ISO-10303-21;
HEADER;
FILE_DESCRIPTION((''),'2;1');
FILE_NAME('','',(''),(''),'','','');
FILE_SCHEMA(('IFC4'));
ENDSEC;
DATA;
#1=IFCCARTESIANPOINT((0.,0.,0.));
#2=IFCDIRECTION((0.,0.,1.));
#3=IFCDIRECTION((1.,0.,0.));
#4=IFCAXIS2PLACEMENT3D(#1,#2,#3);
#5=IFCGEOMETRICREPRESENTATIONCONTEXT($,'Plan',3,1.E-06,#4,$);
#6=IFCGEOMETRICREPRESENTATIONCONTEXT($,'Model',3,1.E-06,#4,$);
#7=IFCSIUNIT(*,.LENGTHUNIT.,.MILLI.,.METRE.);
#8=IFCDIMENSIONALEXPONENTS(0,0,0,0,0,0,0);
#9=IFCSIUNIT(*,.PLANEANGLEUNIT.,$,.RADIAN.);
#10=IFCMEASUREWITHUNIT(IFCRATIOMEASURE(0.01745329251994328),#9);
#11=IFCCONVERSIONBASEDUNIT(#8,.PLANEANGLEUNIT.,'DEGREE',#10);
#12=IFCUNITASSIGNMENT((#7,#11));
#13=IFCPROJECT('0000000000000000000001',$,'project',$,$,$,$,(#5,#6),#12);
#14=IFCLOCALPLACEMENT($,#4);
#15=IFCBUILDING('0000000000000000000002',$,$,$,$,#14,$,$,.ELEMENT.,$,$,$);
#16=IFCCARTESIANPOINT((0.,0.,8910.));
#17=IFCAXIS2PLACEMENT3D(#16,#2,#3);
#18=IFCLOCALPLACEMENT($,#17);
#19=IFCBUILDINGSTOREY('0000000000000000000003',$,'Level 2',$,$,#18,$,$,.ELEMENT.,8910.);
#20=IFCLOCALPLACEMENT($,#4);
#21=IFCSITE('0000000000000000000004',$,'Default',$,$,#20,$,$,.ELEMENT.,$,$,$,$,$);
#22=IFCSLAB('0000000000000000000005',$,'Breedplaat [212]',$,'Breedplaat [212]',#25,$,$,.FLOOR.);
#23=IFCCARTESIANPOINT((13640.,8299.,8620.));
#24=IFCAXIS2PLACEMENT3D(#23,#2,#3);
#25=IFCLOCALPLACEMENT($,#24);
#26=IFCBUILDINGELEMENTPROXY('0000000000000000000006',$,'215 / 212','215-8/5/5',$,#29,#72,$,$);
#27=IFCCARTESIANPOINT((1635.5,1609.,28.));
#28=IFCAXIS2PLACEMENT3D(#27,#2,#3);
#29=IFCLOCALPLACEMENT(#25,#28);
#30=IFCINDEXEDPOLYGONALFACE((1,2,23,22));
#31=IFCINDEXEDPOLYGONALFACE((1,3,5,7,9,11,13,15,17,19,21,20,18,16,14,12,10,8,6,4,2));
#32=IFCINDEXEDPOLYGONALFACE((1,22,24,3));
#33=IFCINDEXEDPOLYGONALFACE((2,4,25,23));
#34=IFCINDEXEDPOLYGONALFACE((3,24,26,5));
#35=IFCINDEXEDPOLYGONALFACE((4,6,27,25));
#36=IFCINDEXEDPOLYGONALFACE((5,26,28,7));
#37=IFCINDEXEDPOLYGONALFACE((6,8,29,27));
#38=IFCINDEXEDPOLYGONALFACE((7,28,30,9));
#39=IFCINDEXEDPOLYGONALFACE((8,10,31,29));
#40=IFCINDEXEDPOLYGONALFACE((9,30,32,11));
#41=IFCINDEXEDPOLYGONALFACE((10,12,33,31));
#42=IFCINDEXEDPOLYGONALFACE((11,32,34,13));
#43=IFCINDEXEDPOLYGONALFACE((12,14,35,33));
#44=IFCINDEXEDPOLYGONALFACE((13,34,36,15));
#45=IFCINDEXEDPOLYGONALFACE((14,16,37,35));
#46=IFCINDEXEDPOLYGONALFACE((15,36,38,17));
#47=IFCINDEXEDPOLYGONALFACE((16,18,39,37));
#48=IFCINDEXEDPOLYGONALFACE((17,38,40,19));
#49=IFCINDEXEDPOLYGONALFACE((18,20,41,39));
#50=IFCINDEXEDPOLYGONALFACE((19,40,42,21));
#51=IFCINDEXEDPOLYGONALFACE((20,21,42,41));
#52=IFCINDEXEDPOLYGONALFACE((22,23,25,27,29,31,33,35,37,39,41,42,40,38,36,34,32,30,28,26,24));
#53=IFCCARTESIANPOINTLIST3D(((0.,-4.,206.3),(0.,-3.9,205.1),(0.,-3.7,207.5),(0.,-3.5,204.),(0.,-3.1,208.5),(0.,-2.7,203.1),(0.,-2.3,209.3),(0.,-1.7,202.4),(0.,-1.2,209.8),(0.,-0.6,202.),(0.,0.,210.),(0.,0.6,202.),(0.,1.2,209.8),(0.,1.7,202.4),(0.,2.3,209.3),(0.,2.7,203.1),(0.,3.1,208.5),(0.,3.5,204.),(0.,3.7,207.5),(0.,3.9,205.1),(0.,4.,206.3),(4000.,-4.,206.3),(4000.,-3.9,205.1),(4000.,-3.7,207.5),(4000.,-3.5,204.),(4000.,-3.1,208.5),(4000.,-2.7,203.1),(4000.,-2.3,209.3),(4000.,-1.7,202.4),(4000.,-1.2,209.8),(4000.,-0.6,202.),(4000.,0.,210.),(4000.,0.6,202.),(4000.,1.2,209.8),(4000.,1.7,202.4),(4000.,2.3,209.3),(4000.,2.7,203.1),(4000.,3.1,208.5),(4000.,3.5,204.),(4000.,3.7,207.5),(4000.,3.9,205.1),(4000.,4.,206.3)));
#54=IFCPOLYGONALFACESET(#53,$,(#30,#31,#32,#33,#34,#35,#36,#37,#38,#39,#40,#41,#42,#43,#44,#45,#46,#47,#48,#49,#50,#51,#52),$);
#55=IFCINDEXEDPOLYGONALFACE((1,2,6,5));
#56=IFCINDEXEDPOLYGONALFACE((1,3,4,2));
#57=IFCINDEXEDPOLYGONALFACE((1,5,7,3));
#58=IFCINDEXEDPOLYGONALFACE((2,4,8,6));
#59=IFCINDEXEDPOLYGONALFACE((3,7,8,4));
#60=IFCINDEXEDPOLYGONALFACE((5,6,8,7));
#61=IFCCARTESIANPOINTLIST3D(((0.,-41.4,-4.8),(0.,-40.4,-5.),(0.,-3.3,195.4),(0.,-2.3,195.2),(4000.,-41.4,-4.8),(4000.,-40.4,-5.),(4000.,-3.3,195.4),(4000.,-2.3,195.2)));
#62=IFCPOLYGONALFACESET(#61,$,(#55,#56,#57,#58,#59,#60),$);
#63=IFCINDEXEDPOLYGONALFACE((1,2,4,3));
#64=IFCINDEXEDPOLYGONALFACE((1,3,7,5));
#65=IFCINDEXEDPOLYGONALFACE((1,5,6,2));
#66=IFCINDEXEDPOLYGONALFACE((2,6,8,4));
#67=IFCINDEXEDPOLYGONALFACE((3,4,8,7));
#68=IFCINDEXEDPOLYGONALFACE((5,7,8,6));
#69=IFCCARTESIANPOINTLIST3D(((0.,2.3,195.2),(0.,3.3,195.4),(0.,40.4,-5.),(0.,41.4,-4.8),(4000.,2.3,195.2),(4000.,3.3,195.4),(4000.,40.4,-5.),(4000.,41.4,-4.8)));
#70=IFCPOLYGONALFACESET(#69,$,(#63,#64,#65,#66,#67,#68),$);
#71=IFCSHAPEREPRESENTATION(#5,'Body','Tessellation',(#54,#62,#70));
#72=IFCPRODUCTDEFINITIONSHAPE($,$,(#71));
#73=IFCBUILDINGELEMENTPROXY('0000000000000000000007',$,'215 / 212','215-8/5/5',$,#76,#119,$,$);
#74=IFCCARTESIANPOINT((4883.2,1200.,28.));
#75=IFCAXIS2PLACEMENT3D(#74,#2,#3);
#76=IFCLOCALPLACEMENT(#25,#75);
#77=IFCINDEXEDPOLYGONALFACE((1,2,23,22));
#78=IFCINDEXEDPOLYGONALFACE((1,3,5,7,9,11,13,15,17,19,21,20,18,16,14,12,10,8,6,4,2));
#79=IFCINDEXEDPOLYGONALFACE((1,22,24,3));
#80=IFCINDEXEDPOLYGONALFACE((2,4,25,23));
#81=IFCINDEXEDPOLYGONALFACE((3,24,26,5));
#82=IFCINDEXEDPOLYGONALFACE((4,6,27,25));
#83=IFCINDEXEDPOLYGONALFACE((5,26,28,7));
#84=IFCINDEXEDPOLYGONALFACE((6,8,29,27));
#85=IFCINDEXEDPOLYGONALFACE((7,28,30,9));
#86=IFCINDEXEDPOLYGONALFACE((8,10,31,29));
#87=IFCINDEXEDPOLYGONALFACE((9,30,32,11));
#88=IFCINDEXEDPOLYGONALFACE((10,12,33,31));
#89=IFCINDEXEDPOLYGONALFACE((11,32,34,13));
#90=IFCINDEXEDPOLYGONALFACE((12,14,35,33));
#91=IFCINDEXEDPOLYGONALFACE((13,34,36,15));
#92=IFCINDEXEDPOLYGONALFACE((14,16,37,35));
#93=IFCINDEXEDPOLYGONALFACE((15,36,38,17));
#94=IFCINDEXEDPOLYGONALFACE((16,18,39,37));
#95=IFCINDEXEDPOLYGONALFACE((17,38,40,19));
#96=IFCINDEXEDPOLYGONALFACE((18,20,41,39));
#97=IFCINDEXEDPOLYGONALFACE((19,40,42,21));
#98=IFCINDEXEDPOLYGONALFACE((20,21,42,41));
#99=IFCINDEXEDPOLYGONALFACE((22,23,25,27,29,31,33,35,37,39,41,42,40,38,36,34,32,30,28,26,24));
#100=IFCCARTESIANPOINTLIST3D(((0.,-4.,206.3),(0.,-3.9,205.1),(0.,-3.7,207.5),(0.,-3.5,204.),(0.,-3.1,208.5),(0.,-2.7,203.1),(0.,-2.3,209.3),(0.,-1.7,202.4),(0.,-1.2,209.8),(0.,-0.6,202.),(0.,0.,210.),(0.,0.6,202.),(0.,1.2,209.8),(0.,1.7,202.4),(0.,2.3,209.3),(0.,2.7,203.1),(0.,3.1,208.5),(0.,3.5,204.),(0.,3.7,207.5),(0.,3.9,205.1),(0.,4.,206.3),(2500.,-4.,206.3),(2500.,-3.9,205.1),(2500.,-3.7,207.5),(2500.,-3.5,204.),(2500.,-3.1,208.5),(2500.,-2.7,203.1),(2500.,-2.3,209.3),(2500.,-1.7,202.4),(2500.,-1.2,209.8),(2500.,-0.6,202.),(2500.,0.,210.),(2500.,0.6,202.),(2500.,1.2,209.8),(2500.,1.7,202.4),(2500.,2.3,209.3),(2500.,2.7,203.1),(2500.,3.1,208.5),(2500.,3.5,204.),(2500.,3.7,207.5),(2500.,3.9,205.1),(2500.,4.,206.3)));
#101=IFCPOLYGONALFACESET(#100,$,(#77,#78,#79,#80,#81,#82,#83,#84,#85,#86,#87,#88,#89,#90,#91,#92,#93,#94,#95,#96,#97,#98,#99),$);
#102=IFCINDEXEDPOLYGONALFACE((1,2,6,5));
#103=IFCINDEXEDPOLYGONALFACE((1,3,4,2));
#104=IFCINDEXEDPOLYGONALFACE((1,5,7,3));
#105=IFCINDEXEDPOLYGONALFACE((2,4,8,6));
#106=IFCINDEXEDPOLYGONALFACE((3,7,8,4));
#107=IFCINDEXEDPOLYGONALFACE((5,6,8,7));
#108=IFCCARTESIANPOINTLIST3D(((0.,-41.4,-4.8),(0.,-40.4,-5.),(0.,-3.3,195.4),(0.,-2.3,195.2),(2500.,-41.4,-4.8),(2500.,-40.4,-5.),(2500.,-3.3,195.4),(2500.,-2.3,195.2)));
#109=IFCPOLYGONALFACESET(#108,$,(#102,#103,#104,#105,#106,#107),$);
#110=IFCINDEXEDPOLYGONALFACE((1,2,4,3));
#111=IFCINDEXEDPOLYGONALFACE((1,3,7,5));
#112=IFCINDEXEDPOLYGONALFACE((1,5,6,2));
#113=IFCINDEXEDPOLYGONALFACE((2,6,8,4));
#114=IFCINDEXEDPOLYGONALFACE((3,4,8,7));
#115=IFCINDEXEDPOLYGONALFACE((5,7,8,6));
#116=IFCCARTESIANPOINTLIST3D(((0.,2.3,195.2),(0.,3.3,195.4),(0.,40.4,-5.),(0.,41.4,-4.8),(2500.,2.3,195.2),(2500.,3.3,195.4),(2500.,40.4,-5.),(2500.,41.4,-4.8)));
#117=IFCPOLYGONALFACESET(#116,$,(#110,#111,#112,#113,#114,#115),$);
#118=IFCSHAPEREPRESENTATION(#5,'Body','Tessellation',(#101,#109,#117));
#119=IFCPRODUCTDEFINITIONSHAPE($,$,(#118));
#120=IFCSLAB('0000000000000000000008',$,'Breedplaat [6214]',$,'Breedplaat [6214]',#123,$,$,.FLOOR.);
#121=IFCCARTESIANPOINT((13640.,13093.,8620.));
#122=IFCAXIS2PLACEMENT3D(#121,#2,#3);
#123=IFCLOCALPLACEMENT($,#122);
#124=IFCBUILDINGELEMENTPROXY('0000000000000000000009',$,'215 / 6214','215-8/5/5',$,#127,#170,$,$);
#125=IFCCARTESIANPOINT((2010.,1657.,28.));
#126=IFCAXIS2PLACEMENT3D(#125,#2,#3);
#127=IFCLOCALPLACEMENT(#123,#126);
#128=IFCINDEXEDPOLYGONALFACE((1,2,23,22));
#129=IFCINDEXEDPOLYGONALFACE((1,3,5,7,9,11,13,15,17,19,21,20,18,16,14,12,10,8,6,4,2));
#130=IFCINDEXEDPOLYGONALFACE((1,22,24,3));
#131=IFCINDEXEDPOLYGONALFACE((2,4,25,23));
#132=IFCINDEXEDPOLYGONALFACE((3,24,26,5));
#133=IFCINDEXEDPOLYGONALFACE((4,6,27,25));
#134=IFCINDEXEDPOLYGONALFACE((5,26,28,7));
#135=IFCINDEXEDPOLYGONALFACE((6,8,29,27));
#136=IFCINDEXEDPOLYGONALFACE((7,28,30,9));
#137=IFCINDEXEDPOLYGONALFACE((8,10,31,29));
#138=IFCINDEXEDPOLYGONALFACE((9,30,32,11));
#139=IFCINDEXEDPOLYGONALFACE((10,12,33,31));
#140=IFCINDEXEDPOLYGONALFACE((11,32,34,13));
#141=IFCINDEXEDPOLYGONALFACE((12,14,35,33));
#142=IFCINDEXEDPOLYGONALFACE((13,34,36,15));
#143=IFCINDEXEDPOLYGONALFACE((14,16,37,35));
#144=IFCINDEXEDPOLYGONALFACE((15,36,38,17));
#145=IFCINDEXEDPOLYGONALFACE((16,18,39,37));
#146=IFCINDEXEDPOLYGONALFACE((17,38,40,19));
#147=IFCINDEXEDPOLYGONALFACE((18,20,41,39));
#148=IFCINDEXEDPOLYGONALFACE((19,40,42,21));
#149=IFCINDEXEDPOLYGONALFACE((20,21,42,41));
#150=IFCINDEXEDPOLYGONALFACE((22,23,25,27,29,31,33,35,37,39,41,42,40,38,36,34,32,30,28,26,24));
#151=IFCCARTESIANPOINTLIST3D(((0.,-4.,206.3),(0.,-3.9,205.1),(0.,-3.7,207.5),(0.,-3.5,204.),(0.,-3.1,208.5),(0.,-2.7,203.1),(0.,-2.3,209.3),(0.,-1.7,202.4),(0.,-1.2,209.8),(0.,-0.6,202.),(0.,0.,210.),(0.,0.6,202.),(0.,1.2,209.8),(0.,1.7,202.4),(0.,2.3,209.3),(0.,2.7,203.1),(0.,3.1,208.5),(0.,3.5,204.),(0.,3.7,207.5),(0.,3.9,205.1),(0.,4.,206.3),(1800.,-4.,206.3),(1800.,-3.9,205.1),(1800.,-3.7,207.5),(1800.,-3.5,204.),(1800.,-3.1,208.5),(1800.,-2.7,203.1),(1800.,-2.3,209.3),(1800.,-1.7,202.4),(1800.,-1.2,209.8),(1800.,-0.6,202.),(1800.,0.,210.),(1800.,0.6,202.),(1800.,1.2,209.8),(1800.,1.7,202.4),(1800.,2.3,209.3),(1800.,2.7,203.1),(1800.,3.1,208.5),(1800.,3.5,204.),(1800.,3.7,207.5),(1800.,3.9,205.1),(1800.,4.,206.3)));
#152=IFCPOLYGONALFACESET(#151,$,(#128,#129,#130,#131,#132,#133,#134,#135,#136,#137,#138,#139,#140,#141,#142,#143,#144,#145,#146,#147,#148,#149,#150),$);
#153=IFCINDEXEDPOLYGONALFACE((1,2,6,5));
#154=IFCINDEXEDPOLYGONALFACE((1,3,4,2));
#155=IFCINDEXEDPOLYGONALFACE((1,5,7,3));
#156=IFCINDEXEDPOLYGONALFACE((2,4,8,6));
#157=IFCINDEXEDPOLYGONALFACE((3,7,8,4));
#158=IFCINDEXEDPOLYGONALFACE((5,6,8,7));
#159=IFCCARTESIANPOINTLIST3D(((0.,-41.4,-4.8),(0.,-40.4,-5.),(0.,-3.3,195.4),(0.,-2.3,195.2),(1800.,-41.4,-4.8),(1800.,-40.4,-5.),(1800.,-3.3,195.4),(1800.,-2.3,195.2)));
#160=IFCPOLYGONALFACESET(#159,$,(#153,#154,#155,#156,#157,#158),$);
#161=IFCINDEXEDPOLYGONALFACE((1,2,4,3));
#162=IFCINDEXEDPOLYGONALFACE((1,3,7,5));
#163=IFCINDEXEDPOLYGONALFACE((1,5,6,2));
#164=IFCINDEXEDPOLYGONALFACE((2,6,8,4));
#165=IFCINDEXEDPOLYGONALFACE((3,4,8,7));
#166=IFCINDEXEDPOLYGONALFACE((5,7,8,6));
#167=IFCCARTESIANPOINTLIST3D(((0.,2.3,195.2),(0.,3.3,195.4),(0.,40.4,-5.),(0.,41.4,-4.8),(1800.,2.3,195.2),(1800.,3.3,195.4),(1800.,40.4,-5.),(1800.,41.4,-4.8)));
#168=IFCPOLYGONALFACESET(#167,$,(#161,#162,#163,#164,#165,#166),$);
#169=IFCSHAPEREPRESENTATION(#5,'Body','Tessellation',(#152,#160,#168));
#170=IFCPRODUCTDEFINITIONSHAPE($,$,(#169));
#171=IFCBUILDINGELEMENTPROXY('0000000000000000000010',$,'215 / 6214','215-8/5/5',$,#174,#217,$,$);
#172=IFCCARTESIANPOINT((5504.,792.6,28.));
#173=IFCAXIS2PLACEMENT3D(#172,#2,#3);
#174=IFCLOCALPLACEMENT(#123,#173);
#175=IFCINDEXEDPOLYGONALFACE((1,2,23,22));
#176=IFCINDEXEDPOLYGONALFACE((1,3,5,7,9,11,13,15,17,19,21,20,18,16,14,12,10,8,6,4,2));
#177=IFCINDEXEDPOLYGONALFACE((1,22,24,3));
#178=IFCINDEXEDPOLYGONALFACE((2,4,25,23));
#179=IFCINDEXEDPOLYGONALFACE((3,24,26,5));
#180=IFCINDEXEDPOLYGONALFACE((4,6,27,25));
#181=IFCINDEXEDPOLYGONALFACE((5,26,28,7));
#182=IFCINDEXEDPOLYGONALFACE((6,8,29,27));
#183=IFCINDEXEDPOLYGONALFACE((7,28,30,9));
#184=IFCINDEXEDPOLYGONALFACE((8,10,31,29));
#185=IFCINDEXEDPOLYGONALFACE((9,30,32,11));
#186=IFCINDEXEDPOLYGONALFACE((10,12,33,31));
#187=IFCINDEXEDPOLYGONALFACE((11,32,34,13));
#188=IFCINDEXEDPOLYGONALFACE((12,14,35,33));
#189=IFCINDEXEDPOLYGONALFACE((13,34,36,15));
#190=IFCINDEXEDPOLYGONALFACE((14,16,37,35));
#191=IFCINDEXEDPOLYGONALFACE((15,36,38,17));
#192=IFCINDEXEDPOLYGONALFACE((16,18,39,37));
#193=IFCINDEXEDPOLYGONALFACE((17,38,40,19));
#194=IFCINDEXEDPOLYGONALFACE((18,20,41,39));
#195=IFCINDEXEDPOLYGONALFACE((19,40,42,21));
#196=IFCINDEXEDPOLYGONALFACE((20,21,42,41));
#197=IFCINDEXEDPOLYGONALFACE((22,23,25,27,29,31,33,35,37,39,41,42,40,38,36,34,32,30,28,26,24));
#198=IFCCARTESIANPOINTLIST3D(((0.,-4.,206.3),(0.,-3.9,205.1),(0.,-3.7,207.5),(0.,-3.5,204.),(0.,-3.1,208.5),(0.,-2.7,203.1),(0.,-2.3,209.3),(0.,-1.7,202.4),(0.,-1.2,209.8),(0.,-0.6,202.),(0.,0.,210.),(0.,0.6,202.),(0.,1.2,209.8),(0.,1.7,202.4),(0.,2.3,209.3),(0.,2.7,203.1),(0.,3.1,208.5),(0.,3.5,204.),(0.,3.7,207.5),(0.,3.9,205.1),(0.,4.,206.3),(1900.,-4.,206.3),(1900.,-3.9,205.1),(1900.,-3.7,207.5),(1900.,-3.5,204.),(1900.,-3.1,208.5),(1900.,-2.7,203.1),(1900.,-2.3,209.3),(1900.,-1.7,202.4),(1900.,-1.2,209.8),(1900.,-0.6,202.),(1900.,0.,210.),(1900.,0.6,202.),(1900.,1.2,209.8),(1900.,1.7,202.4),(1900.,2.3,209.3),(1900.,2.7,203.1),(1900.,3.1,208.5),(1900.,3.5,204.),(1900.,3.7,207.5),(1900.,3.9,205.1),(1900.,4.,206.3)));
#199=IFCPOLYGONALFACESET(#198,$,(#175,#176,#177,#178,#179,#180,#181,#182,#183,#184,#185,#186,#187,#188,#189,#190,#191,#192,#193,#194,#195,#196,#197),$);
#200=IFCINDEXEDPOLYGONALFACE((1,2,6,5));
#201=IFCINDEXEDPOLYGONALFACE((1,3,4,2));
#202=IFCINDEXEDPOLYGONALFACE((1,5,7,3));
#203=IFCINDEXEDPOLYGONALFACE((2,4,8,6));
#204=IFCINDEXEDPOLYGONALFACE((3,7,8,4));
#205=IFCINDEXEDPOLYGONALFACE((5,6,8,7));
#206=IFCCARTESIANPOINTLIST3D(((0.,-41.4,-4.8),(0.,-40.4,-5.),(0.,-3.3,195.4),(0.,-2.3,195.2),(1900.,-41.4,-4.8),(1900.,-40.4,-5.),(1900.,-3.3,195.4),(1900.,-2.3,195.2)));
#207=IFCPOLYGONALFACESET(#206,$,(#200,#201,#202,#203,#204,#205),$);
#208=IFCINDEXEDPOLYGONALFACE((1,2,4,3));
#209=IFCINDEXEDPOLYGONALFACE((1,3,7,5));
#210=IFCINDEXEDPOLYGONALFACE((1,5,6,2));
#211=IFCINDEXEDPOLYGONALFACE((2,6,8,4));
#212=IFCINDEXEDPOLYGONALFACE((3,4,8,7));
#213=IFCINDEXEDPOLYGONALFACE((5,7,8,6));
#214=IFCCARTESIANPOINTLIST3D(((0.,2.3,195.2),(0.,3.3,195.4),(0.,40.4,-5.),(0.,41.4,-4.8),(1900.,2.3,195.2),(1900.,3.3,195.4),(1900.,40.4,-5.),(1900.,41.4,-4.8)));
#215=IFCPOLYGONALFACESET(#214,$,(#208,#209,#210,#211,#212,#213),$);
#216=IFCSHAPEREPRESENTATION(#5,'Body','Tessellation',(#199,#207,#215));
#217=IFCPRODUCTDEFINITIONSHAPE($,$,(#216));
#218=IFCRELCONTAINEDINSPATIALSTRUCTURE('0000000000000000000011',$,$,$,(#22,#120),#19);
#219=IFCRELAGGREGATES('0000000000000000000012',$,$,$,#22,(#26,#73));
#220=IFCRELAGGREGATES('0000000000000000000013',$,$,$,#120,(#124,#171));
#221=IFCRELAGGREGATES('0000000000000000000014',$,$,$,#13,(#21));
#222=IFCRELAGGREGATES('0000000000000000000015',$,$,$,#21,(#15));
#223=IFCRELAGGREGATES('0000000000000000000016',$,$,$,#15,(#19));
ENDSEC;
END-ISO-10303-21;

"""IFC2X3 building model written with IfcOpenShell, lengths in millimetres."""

from ifc_helpers import new_model, entity, si_unit, converted_unit, frame, origin_with_axes, origin_2d_with_axis, place, context, project, spatial, rectangle, circle, extrude, element, aggregate, save


model = new_model("IFC2X3")

# Units and contexts
plan_context = context("Plan", 3, precision=1e-06, world=origin_with_axes())
model_context = context("Model", 3, precision=1e-06, world=origin_with_axes())
ifc_project = project(units=[si_unit("LENGTHUNIT", "METRE", prefix="MILLI"), converted_unit("PLANEANGLEUNIT", "DEGREE", entity("IfcRatioMeasure", 0.01745329251994328), si_unit("PLANEANGLEUNIT", "RADIAN"), dimensions=[0, 0, 0, 0, 0, 0, 0])], contexts=[plan_context, model_context])

# Site, building, storey
site_placement = place(None, origin_with_axes())
site = spatial("IfcSite", under=ifc_project, at=site_placement, Name="Default", CompositionType="ELEMENT")
building_placement = place(None, origin_with_axes())
building = spatial("IfcBuilding", under=site, at=building_placement, CompositionType="ELEMENT")
storey_placement = place(None, frame((0.0, 0.0, 8910.0), z_axis=(0.0, 0.0, 1.0), x_axis=(1.0, 0.0, 0.0)))
storey = spatial("IfcBuildingStorey", under=building, at=storey_placement, Name="Level 2", CompositionType="ELEMENT", Elevation=8910.0)

# Slabs, building element proxies
slab_1_placement = place(None, frame((13640.0, 8299.0, 8620.0), z_axis=(0.0, 0.0, 1.0), x_axis=(1.0, 0.0, 0.0)))
slab_1 = element("IfcSlab", 1, at=slab_1_placement, inside=storey, Name="Breedplaat [212]", ObjectType="Breedplaat [212]", PredefinedType="FLOOR")
proxy_1_placement = place(slab_1_placement, frame((1635.5, 1609.0, 28.0), z_axis=(0.0, 0.0, 1.0), x_axis=(1.0, 0.0, 0.0)))
proxy_1 = element("IfcBuildingElementProxy", 2, at=proxy_1_placement, Name="215 / 212", Description="215-8/5/5", context=plan_context, shape_type="SweptSolid", body=[
    extrude(circle(Radius=4.0, at=origin_2d_with_axis()), frame((0.0, 0.0, 206.0), z_axis=(1.0, 0.0, 0.0), x_axis=(0.0, 0.0, 1.0)), (0.0, 0.0, 1.0), 4000.0),
    extrude(rectangle(XDim=203.8, YDim=1.0, at=origin_2d_with_axis()), frame((0.0, -21.9, 95.2), z_axis=(1.0, 0.0, 0.0), x_axis=(0.0, 0.187112, 0.982339)), (0.0, 0.0, 1.0), 4000.0),
    extrude(rectangle(XDim=203.8, YDim=1.0, at=origin_2d_with_axis()), frame((0.0, 21.9, 95.2), z_axis=(1.0, 0.0, 0.0), x_axis=(0.0, -0.187112, 0.982339)), (0.0, 0.0, 1.0), 4000.0),
])
proxy_2_placement = place(slab_1_placement, frame((4883.2, 1200.0, 28.0), z_axis=(0.0, 0.0, 1.0), x_axis=(1.0, 0.0, 0.0)))
proxy_2 = element("IfcBuildingElementProxy", 3, at=proxy_2_placement, Name="215 / 212", Description="215-8/5/5", context=plan_context, shape_type="SweptSolid", body=[
    extrude(circle(Radius=4.0, at=origin_2d_with_axis()), frame((0.0, 0.0, 206.0), z_axis=(1.0, 0.0, 0.0), x_axis=(0.0, 0.0, 1.0)), (0.0, 0.0, 1.0), 2500.0),
    extrude(rectangle(XDim=203.8, YDim=1.0, at=origin_2d_with_axis()), frame((0.0, -21.9, 95.2), z_axis=(1.0, 0.0, 0.0), x_axis=(0.0, 0.187112, 0.982339)), (0.0, 0.0, 1.0), 2500.0),
    extrude(rectangle(XDim=203.8, YDim=1.0, at=origin_2d_with_axis()), frame((0.0, 21.9, 95.2), z_axis=(1.0, 0.0, 0.0), x_axis=(0.0, -0.187112, 0.982339)), (0.0, 0.0, 1.0), 2500.0),
])
aggregate(slab_1, [proxy_1, proxy_2])
slab_2_placement = place(None, frame((13640.0, 13093.0, 8620.0), z_axis=(0.0, 0.0, 1.0), x_axis=(1.0, 0.0, 0.0)))
slab_2 = element("IfcSlab", 4, at=slab_2_placement, inside=storey, Name="Breedplaat [6214]", ObjectType="Breedplaat [6214]", PredefinedType="FLOOR")
proxy_3_placement = place(slab_2_placement, frame((2010.0, 1657.0, 28.0), z_axis=(0.0, 0.0, 1.0), x_axis=(1.0, 0.0, 0.0)))
proxy_3 = element("IfcBuildingElementProxy", 5, at=proxy_3_placement, Name="215 / 6214", Description="215-8/5/5", context=plan_context, shape_type="SweptSolid", body=[
    extrude(circle(Radius=4.0, at=origin_2d_with_axis()), frame((0.0, 0.0, 206.0), z_axis=(1.0, 0.0, 0.0), x_axis=(0.0, 0.0, 1.0)), (0.0, 0.0, 1.0), 1800.0),
    extrude(rectangle(XDim=203.8, YDim=1.0, at=origin_2d_with_axis()), frame((0.0, -21.9, 95.2), z_axis=(1.0, 0.0, 0.0), x_axis=(0.0, 0.187112, 0.982339)), (0.0, 0.0, 1.0), 1800.0),
    extrude(rectangle(XDim=203.8, YDim=1.0, at=origin_2d_with_axis()), frame((0.0, 21.9, 95.2), z_axis=(1.0, 0.0, 0.0), x_axis=(0.0, -0.187112, 0.982339)), (0.0, 0.0, 1.0), 1800.0),
])
proxy_4_placement = place(slab_2_placement, frame((5504.0, 792.6, 28.0), z_axis=(0.0, 0.0, 1.0), x_axis=(1.0, 0.0, 0.0)))
proxy_4 = element("IfcBuildingElementProxy", 6, at=proxy_4_placement, Name="215 / 6214", Description="215-8/5/5", context=plan_context, shape_type="SweptSolid", body=[
    extrude(circle(Radius=4.0, at=origin_2d_with_axis()), frame((0.0, 0.0, 206.0), z_axis=(1.0, 0.0, 0.0), x_axis=(0.0, 0.0, 1.0)), (0.0, 0.0, 1.0), 1900.0),
    extrude(rectangle(XDim=203.8, YDim=1.0, at=origin_2d_with_axis()), frame((0.0, -21.9, 95.2), z_axis=(1.0, 0.0, 0.0), x_axis=(0.0, 0.187112, 0.982339)), (0.0, 0.0, 1.0), 1900.0),
    extrude(rectangle(XDim=203.8, YDim=1.0, at=origin_2d_with_axis()), frame((0.0, 21.9, 95.2), z_axis=(1.0, 0.0, 0.0), x_axis=(0.0, -0.187112, 0.982339)), (0.0, 0.0, 1.0), 1900.0),
])
aggregate(slab_2, [proxy_3, proxy_4])

save(model, "model.ifc")
